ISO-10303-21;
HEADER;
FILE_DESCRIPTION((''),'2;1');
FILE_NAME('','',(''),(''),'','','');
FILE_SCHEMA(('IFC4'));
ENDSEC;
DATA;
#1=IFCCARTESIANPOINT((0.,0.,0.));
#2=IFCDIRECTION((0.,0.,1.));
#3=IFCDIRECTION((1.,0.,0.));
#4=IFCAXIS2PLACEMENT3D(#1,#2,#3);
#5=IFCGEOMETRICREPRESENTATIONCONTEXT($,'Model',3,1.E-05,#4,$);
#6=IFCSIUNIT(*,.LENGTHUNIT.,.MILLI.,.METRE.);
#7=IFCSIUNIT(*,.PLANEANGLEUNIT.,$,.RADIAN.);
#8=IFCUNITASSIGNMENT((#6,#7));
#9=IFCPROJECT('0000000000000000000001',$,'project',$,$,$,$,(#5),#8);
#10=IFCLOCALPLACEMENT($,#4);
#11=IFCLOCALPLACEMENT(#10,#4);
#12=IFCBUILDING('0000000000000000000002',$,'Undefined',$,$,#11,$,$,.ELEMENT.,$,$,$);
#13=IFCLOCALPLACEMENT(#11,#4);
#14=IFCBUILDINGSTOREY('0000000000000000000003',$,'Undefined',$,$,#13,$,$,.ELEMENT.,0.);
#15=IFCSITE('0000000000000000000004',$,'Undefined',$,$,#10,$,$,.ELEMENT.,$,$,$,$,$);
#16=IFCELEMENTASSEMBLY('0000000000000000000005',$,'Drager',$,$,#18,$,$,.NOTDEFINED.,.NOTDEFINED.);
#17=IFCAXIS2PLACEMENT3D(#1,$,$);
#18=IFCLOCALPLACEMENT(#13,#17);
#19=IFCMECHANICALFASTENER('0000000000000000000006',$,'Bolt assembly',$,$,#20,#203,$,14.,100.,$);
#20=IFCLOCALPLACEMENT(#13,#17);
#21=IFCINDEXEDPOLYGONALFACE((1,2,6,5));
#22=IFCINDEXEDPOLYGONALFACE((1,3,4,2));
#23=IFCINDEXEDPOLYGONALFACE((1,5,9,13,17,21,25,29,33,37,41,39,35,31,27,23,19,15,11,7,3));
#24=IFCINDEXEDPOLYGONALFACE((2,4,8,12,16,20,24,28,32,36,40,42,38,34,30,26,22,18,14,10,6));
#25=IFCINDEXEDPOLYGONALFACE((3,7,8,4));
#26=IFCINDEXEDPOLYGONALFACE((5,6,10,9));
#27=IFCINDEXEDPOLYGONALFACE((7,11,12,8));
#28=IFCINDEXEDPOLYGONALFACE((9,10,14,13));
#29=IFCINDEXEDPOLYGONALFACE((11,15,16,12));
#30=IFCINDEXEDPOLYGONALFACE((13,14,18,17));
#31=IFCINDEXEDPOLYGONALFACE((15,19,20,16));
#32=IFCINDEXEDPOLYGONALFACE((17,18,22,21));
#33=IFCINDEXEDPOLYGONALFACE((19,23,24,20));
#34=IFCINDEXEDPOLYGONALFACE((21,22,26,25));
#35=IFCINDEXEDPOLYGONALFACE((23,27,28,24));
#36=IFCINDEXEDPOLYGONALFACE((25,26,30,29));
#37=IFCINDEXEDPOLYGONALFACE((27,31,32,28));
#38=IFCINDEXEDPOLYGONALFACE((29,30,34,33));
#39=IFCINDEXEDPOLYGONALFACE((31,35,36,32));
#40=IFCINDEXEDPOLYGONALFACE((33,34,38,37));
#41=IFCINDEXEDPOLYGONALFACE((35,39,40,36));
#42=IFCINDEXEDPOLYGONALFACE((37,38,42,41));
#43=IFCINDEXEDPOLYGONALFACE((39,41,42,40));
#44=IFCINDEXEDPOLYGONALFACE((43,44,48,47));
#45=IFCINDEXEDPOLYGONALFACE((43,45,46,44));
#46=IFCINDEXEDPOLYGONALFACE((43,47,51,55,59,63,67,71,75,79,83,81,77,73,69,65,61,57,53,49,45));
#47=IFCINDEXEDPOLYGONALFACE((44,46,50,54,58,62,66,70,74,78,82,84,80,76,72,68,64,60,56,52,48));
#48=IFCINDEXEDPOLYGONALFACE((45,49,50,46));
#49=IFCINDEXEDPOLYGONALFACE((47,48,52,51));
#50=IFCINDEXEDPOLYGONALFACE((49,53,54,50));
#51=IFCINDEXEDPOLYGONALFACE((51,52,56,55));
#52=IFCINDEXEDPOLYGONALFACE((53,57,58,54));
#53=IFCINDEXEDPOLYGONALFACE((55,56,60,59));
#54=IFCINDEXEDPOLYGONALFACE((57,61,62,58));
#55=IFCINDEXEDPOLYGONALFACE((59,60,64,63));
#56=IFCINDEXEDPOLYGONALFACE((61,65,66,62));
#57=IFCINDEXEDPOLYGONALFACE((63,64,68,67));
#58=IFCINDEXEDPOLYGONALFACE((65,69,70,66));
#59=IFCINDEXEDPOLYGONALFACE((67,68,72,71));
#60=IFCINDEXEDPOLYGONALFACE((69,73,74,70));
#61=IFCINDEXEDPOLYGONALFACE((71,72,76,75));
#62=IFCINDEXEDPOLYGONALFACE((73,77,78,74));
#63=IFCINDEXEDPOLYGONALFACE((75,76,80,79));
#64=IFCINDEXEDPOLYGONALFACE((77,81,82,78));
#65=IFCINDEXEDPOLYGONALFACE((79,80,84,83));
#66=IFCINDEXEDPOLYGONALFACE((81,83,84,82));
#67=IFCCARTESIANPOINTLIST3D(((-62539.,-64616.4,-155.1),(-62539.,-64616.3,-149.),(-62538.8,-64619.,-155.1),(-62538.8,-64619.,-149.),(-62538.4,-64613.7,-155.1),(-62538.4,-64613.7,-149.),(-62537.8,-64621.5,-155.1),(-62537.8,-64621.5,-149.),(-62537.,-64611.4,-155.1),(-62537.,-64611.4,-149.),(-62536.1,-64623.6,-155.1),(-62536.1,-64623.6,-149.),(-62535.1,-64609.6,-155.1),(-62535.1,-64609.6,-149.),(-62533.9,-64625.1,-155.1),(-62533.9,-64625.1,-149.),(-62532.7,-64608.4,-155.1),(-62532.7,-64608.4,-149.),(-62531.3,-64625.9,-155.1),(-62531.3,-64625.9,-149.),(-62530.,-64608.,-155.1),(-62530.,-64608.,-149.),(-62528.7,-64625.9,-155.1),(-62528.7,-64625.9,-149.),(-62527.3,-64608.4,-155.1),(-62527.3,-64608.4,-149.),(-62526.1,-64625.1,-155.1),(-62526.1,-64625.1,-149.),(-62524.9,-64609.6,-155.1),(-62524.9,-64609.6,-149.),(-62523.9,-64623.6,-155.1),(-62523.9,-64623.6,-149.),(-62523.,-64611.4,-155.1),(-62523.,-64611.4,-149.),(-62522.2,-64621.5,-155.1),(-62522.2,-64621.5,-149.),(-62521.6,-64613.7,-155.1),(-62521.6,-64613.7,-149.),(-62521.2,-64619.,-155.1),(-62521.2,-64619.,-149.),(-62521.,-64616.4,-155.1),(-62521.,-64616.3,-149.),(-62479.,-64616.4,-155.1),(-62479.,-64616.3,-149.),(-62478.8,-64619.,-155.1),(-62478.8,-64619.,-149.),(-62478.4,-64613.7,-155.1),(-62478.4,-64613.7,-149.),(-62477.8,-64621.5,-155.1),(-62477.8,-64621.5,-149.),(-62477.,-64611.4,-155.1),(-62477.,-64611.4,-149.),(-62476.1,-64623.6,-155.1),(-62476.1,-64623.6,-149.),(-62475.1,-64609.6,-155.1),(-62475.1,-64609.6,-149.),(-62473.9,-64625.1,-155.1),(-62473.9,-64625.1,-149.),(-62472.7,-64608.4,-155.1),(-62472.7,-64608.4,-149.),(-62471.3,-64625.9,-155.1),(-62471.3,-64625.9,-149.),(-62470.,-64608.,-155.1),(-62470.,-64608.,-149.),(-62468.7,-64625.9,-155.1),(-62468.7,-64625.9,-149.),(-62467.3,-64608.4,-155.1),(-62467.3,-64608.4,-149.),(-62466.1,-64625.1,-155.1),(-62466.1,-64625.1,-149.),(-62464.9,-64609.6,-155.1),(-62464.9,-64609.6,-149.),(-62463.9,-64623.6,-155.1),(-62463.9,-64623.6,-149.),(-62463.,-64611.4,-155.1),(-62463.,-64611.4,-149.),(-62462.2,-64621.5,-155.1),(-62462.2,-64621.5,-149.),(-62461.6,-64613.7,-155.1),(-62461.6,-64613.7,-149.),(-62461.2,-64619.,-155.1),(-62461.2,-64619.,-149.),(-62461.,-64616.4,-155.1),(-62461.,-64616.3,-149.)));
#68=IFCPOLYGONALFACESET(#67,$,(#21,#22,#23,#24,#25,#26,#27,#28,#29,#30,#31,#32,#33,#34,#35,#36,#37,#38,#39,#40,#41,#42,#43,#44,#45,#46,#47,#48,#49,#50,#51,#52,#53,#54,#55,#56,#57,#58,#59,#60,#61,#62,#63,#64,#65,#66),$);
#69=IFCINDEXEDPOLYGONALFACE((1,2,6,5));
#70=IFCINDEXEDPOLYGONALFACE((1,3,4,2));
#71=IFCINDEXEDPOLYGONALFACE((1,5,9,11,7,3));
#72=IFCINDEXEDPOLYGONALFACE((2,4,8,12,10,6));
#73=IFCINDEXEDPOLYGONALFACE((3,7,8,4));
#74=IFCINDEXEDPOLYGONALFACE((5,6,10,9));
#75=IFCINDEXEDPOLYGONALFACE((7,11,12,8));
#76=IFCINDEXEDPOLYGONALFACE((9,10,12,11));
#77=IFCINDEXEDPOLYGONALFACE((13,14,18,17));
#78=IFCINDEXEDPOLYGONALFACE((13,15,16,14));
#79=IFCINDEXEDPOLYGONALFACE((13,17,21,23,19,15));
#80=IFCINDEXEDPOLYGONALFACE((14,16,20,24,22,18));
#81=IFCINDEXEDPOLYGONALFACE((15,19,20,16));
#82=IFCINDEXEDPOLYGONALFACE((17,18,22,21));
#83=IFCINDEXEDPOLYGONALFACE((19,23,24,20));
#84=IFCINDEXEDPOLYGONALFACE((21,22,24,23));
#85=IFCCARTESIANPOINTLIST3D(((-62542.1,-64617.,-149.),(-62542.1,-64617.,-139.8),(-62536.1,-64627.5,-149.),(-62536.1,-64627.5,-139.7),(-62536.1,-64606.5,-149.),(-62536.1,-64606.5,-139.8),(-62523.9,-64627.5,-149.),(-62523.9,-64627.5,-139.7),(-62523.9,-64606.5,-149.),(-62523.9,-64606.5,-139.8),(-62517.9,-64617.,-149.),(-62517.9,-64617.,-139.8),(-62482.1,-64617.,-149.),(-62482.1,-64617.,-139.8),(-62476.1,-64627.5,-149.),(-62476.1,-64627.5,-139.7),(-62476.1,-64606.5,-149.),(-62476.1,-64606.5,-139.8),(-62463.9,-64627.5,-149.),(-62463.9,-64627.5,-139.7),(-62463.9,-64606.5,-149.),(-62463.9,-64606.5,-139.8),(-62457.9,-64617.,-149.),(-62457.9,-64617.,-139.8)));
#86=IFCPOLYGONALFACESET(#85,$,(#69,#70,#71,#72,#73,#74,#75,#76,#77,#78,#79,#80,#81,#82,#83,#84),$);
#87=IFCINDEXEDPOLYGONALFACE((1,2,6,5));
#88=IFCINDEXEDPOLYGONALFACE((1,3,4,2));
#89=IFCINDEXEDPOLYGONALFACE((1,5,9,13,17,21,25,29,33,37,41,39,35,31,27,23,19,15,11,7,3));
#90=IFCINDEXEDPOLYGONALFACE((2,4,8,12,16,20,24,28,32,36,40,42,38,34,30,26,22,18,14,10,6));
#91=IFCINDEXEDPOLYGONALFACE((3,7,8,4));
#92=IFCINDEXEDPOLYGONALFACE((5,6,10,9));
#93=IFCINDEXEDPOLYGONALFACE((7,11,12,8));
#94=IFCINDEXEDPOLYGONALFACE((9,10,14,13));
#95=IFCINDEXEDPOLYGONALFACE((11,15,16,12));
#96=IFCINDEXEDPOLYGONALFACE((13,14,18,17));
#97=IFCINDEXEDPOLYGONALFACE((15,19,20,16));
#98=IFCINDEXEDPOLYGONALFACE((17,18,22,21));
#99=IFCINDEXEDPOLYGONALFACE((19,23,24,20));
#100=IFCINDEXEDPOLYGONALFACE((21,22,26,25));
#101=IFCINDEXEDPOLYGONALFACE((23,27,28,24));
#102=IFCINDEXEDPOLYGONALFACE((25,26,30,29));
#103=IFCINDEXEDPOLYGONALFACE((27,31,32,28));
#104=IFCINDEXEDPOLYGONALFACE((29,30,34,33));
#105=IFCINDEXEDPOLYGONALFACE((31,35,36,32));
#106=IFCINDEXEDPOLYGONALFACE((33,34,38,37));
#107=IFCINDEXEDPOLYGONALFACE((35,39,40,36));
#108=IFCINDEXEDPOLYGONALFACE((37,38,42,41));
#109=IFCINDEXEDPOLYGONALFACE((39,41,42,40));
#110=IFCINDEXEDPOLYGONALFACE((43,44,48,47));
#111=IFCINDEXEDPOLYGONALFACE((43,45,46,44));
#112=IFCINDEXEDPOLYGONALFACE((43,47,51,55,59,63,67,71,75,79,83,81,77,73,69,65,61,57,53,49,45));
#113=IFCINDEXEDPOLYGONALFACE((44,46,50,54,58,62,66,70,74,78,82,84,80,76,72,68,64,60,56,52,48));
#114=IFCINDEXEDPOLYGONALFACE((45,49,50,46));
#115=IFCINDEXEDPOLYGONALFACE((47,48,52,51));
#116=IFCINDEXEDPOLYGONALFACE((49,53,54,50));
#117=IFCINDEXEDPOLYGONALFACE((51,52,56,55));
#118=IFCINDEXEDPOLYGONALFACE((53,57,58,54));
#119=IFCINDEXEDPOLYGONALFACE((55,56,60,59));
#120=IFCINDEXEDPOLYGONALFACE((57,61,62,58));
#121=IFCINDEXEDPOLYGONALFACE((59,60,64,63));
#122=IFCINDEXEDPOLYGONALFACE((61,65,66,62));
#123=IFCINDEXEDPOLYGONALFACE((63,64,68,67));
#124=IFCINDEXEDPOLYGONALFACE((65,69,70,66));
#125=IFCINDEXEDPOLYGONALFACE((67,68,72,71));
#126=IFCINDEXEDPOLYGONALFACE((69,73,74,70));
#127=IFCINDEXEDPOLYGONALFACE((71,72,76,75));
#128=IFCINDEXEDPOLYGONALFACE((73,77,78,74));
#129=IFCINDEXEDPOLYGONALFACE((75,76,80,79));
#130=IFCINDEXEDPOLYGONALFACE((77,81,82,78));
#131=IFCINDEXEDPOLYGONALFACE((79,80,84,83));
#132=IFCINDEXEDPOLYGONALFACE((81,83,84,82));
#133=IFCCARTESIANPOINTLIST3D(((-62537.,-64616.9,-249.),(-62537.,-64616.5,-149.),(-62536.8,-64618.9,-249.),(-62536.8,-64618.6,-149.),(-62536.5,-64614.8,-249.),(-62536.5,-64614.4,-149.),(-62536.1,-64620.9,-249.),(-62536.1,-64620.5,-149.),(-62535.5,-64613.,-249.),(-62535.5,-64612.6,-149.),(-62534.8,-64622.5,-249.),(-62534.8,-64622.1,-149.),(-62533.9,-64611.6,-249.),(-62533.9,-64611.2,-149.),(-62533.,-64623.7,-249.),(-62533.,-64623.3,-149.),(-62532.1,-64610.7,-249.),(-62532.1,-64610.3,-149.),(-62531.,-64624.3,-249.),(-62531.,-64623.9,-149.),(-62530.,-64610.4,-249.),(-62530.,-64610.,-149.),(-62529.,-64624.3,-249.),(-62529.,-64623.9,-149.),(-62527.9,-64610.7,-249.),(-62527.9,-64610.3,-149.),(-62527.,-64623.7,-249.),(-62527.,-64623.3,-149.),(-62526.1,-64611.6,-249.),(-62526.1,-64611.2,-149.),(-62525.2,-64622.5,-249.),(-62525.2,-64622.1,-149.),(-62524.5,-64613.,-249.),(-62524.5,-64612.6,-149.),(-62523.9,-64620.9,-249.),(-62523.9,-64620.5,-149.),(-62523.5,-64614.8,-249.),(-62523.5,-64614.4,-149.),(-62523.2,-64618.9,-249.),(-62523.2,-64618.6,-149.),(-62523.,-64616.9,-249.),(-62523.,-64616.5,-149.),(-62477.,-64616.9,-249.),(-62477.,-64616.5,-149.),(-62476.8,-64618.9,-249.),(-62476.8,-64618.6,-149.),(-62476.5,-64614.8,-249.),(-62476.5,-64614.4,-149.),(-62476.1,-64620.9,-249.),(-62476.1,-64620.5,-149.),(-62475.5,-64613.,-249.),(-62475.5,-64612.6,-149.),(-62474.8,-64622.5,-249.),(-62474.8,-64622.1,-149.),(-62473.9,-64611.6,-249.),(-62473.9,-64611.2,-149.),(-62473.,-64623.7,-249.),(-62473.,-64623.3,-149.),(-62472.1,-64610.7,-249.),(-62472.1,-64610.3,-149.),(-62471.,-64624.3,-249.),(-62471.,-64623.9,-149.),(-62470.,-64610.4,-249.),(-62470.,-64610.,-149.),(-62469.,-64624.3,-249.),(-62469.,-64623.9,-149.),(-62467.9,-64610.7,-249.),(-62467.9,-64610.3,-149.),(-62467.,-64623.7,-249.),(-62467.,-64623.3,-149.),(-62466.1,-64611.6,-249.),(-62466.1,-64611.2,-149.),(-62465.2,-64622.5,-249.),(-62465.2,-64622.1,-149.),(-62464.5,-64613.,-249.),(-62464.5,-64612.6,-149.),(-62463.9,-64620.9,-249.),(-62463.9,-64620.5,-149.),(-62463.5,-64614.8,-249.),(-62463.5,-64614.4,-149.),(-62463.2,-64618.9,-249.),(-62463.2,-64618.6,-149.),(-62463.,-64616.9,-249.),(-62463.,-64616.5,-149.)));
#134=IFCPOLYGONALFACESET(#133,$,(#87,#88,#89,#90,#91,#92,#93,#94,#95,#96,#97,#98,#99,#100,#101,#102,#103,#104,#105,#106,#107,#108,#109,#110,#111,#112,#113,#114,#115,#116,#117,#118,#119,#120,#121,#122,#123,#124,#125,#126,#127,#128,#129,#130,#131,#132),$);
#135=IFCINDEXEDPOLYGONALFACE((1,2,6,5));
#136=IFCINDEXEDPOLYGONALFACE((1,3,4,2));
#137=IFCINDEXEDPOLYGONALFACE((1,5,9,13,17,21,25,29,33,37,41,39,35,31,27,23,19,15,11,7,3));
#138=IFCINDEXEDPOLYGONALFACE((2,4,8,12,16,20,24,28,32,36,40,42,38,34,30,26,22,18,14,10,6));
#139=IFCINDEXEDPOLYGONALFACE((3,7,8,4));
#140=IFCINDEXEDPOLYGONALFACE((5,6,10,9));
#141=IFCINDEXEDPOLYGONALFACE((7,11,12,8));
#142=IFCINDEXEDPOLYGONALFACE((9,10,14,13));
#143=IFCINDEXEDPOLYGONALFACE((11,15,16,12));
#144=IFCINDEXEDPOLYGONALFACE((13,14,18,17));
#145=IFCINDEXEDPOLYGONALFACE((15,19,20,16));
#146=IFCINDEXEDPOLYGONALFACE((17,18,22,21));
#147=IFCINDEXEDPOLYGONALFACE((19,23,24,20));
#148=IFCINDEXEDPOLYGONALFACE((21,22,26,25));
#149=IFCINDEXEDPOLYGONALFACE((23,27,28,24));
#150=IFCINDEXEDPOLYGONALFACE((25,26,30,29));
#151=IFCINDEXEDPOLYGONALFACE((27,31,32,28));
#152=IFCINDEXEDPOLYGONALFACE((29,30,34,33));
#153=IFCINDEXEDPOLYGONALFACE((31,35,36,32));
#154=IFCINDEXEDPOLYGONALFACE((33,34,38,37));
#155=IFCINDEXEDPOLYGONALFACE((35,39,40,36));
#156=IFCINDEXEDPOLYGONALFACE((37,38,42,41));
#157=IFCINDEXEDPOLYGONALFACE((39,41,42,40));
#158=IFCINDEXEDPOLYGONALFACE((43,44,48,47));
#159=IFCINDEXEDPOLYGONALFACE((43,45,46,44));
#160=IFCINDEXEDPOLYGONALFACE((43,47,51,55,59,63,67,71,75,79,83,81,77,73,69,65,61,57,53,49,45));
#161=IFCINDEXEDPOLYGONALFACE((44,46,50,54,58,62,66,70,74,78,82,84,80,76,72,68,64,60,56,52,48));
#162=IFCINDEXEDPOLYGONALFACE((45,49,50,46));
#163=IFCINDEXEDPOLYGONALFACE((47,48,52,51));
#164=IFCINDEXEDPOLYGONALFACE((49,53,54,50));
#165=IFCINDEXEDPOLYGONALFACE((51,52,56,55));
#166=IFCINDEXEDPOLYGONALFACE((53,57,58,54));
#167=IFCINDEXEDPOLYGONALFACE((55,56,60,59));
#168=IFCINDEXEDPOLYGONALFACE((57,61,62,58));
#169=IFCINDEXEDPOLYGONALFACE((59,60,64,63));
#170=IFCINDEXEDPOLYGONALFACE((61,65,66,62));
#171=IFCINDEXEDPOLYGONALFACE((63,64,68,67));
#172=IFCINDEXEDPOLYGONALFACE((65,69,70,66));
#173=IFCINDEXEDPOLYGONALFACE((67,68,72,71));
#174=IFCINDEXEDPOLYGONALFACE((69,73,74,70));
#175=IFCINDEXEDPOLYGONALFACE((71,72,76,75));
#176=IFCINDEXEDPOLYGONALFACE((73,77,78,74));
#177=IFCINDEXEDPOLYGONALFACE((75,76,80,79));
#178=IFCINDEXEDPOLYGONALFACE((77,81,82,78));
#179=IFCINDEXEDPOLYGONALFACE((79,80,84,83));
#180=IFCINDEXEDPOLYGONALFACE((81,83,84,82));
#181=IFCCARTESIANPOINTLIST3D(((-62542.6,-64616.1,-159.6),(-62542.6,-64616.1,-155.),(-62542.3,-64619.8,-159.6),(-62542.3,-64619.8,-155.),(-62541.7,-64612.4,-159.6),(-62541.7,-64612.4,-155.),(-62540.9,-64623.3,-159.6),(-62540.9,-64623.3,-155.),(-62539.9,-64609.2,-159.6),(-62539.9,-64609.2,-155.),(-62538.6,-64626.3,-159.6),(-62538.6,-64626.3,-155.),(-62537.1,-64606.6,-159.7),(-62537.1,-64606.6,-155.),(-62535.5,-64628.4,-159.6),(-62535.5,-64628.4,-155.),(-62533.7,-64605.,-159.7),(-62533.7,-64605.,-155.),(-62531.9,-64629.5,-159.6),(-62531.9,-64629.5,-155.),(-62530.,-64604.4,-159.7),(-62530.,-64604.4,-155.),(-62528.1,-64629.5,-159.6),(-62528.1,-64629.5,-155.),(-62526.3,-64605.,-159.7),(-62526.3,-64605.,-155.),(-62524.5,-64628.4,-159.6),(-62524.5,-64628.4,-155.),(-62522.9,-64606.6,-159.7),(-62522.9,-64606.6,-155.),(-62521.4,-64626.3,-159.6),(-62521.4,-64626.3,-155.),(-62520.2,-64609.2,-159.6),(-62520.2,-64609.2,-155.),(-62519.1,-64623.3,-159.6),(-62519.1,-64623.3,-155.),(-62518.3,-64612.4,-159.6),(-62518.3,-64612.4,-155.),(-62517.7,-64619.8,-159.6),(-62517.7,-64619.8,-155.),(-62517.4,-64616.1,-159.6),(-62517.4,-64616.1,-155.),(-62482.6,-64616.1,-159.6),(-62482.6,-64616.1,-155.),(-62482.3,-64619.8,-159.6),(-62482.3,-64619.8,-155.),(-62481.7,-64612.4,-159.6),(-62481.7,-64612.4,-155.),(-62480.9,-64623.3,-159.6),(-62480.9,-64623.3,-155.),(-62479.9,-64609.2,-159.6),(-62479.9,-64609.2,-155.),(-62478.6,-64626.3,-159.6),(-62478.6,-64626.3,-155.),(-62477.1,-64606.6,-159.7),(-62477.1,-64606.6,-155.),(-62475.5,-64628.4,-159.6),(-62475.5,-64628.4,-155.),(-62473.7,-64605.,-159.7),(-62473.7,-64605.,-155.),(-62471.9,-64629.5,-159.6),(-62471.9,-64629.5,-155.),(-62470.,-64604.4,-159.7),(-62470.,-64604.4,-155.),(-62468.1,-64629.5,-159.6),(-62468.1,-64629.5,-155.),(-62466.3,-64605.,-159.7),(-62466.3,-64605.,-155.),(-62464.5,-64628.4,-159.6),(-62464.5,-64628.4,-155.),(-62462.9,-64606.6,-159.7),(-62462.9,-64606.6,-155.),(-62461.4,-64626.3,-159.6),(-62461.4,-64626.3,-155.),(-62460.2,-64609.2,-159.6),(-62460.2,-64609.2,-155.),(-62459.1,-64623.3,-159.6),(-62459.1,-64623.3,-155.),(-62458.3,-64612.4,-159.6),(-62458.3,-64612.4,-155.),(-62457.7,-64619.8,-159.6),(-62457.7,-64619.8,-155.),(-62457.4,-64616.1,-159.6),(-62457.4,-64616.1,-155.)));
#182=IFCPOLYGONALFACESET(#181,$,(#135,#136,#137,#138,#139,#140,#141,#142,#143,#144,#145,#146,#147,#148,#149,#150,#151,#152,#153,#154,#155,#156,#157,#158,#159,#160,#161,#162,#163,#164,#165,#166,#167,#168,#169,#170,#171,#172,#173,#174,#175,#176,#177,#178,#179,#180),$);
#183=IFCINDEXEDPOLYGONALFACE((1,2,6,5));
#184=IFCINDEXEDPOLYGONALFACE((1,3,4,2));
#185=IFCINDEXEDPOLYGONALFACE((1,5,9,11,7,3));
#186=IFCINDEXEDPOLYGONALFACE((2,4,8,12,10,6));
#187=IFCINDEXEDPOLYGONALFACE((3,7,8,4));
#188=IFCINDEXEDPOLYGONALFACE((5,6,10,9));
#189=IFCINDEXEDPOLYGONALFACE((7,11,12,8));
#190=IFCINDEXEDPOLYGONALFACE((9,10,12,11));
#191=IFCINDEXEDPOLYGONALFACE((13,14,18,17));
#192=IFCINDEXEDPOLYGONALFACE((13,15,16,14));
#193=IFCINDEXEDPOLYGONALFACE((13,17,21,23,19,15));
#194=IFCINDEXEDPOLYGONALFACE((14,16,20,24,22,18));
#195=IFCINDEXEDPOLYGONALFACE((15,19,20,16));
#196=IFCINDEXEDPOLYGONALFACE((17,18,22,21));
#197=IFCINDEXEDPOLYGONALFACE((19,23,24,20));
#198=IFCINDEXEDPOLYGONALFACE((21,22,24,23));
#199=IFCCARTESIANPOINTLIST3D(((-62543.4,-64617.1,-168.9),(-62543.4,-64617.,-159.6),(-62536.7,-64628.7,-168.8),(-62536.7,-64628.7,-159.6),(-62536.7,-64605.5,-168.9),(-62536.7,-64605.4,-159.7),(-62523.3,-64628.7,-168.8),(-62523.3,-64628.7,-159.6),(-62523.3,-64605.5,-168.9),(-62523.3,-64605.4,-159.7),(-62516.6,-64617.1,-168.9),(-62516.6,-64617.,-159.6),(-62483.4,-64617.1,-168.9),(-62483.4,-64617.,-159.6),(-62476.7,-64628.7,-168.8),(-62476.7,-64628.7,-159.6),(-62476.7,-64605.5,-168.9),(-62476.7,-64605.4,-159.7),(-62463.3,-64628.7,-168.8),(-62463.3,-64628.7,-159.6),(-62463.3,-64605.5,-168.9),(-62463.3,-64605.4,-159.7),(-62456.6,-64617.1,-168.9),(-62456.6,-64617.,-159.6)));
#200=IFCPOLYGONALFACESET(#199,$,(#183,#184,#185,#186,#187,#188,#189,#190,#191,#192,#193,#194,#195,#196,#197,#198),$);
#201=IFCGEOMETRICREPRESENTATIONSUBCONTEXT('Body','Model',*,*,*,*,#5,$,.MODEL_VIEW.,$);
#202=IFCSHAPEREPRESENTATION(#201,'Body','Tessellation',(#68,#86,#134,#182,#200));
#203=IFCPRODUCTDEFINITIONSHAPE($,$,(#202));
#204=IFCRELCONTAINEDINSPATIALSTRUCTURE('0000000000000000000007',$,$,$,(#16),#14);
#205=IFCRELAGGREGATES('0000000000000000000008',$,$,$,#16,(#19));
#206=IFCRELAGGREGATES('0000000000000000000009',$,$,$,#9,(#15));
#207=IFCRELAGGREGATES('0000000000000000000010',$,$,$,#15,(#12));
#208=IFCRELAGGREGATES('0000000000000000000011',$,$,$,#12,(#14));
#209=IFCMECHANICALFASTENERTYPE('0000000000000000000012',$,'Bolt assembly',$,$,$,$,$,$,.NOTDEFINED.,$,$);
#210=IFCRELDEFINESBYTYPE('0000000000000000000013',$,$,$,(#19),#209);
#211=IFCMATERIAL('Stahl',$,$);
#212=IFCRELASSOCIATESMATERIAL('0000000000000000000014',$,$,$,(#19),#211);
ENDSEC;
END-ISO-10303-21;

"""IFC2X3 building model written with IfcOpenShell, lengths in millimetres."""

from ifc_helpers import new_model, si_unit, frame, origin_with_axes, origin_2d_with_axis, place, context, subcontext, project, spatial, polyline, circle, outline, extrude, source, transform, mapped, material, type_object, element, aggregate, save


model = new_model("IFC2X3")

# Units and contexts
model_context = context("Model", 3, precision=1e-05, world=origin_with_axes())
body_context = subcontext(model_context, "Body", "Model", "MODEL_VIEW")
ifc_project = project(units=[si_unit("LENGTHUNIT", "METRE", prefix="MILLI"), si_unit("PLANEANGLEUNIT", "RADIAN")], contexts=[model_context])

# Site, building, storey
site_placement = place(None, origin_with_axes())
site = spatial("IfcSite", under=ifc_project, at=site_placement, Name="Undefined", CompositionType="ELEMENT")
building_placement = place(site_placement, origin_with_axes())
building = spatial("IfcBuilding", under=site, at=building_placement, Name="Undefined", CompositionType="ELEMENT")
storey_placement = place(building_placement, origin_with_axes())
storey = spatial("IfcBuildingStorey", under=building, at=storey_placement, Name="Undefined", CompositionType="ELEMENT", Elevation=0.0)

# Element assembly
assembly_1_placement = place(storey_placement, origin_with_axes())
assembly_1 = element("IfcElementAssembly", 1, at=assembly_1_placement, inside=storey, Name="Drager", AssemblyPlace="NOTDEFINED", PredefinedType="NOTDEFINED")

# Shared definitions
mechanical_fastener_type = type_object("IfcMechanicalFastenerType", Name="Bolt assembly")
ifc_material_1 = material(Name="Stahl")

# Mechanical fastener
shared_shape_1 = source(origin_with_axes(), body_context, "Body", "SweptSolid", [
    extrude(circle(Radius=9.0, at=origin_2d_with_axis()), frame((0.0, 0.2, 0.0), z_axis=(0.0, 1.0, 0.0), x_axis=(1.0, 0.0, 0.0)), (0.0, 0.0, 1.0), 6.1),
    extrude(outline(polyline([(10.5, -6.1), (10.5, 6.1), (0.0, 12.1), (-10.5, 6.1), (-10.5, -6.1), (0.0, -12.1), (10.5, -6.1)])), frame((0.0, -9.1, 0.0), z_axis=(0.0, 1.0, 0.0), x_axis=(1.0, 0.0, 0.0)), (0.0, 0.0, 1.0), 9.2),
    extrude(circle(Radius=7.0, at=origin_2d_with_axis()), frame((0.0, 0.2, 0.0), z_axis=(0.0, 1.0, 0.0), x_axis=(1.0, 0.0, 0.0)), (0.0, 0.0, 1.0), 100.0),
    extrude(circle(Radius=12.6, at=origin_2d_with_axis()), frame((0.0, 6.2, 0.0), z_axis=(0.0, 1.0, 0.0), x_axis=(1.0, 0.0, 0.0)), (0.0, 0.0, 1.0), 4.6),
    extrude(outline(polyline([(11.6, -6.7), (11.6, 6.7), (0.0, 13.4), (-11.6, 6.7), (-11.6, -6.7), (0.0, -13.4), (11.6, -6.7)])), frame((0.0, 10.8, 0.0), z_axis=(0.0, 1.0, 0.0), x_axis=(1.0, 0.0, 0.0)), (0.0, 0.0, 1.0), 9.2),
])
mechanical_fastener_1_placement = place(assembly_1_placement, frame((-62500.0, -64617.0, -148.8), z_axis=(-1.0, 0.0, 0.0), x_axis=(-0.000001, 0.999993, -0.00375)))
mechanical_fastener_1 = element("IfcMechanicalFastener", 2, at=mechanical_fastener_1_placement, type_object=mechanical_fastener_type, material=ifc_material_1, Name="Bolt assembly", NominalDiameter=14.0, NominalLength=100.0, context=body_context, shape_type="MappedRepresentation", body=[
    mapped(shared_shape_1, transform((0.0, 0.0, -30.0))),
    mapped(shared_shape_1, transform((0.0, 0.0, 30.0))),
])
aggregate(assembly_1, [mechanical_fastener_1])

save(model, "model.ifc")
